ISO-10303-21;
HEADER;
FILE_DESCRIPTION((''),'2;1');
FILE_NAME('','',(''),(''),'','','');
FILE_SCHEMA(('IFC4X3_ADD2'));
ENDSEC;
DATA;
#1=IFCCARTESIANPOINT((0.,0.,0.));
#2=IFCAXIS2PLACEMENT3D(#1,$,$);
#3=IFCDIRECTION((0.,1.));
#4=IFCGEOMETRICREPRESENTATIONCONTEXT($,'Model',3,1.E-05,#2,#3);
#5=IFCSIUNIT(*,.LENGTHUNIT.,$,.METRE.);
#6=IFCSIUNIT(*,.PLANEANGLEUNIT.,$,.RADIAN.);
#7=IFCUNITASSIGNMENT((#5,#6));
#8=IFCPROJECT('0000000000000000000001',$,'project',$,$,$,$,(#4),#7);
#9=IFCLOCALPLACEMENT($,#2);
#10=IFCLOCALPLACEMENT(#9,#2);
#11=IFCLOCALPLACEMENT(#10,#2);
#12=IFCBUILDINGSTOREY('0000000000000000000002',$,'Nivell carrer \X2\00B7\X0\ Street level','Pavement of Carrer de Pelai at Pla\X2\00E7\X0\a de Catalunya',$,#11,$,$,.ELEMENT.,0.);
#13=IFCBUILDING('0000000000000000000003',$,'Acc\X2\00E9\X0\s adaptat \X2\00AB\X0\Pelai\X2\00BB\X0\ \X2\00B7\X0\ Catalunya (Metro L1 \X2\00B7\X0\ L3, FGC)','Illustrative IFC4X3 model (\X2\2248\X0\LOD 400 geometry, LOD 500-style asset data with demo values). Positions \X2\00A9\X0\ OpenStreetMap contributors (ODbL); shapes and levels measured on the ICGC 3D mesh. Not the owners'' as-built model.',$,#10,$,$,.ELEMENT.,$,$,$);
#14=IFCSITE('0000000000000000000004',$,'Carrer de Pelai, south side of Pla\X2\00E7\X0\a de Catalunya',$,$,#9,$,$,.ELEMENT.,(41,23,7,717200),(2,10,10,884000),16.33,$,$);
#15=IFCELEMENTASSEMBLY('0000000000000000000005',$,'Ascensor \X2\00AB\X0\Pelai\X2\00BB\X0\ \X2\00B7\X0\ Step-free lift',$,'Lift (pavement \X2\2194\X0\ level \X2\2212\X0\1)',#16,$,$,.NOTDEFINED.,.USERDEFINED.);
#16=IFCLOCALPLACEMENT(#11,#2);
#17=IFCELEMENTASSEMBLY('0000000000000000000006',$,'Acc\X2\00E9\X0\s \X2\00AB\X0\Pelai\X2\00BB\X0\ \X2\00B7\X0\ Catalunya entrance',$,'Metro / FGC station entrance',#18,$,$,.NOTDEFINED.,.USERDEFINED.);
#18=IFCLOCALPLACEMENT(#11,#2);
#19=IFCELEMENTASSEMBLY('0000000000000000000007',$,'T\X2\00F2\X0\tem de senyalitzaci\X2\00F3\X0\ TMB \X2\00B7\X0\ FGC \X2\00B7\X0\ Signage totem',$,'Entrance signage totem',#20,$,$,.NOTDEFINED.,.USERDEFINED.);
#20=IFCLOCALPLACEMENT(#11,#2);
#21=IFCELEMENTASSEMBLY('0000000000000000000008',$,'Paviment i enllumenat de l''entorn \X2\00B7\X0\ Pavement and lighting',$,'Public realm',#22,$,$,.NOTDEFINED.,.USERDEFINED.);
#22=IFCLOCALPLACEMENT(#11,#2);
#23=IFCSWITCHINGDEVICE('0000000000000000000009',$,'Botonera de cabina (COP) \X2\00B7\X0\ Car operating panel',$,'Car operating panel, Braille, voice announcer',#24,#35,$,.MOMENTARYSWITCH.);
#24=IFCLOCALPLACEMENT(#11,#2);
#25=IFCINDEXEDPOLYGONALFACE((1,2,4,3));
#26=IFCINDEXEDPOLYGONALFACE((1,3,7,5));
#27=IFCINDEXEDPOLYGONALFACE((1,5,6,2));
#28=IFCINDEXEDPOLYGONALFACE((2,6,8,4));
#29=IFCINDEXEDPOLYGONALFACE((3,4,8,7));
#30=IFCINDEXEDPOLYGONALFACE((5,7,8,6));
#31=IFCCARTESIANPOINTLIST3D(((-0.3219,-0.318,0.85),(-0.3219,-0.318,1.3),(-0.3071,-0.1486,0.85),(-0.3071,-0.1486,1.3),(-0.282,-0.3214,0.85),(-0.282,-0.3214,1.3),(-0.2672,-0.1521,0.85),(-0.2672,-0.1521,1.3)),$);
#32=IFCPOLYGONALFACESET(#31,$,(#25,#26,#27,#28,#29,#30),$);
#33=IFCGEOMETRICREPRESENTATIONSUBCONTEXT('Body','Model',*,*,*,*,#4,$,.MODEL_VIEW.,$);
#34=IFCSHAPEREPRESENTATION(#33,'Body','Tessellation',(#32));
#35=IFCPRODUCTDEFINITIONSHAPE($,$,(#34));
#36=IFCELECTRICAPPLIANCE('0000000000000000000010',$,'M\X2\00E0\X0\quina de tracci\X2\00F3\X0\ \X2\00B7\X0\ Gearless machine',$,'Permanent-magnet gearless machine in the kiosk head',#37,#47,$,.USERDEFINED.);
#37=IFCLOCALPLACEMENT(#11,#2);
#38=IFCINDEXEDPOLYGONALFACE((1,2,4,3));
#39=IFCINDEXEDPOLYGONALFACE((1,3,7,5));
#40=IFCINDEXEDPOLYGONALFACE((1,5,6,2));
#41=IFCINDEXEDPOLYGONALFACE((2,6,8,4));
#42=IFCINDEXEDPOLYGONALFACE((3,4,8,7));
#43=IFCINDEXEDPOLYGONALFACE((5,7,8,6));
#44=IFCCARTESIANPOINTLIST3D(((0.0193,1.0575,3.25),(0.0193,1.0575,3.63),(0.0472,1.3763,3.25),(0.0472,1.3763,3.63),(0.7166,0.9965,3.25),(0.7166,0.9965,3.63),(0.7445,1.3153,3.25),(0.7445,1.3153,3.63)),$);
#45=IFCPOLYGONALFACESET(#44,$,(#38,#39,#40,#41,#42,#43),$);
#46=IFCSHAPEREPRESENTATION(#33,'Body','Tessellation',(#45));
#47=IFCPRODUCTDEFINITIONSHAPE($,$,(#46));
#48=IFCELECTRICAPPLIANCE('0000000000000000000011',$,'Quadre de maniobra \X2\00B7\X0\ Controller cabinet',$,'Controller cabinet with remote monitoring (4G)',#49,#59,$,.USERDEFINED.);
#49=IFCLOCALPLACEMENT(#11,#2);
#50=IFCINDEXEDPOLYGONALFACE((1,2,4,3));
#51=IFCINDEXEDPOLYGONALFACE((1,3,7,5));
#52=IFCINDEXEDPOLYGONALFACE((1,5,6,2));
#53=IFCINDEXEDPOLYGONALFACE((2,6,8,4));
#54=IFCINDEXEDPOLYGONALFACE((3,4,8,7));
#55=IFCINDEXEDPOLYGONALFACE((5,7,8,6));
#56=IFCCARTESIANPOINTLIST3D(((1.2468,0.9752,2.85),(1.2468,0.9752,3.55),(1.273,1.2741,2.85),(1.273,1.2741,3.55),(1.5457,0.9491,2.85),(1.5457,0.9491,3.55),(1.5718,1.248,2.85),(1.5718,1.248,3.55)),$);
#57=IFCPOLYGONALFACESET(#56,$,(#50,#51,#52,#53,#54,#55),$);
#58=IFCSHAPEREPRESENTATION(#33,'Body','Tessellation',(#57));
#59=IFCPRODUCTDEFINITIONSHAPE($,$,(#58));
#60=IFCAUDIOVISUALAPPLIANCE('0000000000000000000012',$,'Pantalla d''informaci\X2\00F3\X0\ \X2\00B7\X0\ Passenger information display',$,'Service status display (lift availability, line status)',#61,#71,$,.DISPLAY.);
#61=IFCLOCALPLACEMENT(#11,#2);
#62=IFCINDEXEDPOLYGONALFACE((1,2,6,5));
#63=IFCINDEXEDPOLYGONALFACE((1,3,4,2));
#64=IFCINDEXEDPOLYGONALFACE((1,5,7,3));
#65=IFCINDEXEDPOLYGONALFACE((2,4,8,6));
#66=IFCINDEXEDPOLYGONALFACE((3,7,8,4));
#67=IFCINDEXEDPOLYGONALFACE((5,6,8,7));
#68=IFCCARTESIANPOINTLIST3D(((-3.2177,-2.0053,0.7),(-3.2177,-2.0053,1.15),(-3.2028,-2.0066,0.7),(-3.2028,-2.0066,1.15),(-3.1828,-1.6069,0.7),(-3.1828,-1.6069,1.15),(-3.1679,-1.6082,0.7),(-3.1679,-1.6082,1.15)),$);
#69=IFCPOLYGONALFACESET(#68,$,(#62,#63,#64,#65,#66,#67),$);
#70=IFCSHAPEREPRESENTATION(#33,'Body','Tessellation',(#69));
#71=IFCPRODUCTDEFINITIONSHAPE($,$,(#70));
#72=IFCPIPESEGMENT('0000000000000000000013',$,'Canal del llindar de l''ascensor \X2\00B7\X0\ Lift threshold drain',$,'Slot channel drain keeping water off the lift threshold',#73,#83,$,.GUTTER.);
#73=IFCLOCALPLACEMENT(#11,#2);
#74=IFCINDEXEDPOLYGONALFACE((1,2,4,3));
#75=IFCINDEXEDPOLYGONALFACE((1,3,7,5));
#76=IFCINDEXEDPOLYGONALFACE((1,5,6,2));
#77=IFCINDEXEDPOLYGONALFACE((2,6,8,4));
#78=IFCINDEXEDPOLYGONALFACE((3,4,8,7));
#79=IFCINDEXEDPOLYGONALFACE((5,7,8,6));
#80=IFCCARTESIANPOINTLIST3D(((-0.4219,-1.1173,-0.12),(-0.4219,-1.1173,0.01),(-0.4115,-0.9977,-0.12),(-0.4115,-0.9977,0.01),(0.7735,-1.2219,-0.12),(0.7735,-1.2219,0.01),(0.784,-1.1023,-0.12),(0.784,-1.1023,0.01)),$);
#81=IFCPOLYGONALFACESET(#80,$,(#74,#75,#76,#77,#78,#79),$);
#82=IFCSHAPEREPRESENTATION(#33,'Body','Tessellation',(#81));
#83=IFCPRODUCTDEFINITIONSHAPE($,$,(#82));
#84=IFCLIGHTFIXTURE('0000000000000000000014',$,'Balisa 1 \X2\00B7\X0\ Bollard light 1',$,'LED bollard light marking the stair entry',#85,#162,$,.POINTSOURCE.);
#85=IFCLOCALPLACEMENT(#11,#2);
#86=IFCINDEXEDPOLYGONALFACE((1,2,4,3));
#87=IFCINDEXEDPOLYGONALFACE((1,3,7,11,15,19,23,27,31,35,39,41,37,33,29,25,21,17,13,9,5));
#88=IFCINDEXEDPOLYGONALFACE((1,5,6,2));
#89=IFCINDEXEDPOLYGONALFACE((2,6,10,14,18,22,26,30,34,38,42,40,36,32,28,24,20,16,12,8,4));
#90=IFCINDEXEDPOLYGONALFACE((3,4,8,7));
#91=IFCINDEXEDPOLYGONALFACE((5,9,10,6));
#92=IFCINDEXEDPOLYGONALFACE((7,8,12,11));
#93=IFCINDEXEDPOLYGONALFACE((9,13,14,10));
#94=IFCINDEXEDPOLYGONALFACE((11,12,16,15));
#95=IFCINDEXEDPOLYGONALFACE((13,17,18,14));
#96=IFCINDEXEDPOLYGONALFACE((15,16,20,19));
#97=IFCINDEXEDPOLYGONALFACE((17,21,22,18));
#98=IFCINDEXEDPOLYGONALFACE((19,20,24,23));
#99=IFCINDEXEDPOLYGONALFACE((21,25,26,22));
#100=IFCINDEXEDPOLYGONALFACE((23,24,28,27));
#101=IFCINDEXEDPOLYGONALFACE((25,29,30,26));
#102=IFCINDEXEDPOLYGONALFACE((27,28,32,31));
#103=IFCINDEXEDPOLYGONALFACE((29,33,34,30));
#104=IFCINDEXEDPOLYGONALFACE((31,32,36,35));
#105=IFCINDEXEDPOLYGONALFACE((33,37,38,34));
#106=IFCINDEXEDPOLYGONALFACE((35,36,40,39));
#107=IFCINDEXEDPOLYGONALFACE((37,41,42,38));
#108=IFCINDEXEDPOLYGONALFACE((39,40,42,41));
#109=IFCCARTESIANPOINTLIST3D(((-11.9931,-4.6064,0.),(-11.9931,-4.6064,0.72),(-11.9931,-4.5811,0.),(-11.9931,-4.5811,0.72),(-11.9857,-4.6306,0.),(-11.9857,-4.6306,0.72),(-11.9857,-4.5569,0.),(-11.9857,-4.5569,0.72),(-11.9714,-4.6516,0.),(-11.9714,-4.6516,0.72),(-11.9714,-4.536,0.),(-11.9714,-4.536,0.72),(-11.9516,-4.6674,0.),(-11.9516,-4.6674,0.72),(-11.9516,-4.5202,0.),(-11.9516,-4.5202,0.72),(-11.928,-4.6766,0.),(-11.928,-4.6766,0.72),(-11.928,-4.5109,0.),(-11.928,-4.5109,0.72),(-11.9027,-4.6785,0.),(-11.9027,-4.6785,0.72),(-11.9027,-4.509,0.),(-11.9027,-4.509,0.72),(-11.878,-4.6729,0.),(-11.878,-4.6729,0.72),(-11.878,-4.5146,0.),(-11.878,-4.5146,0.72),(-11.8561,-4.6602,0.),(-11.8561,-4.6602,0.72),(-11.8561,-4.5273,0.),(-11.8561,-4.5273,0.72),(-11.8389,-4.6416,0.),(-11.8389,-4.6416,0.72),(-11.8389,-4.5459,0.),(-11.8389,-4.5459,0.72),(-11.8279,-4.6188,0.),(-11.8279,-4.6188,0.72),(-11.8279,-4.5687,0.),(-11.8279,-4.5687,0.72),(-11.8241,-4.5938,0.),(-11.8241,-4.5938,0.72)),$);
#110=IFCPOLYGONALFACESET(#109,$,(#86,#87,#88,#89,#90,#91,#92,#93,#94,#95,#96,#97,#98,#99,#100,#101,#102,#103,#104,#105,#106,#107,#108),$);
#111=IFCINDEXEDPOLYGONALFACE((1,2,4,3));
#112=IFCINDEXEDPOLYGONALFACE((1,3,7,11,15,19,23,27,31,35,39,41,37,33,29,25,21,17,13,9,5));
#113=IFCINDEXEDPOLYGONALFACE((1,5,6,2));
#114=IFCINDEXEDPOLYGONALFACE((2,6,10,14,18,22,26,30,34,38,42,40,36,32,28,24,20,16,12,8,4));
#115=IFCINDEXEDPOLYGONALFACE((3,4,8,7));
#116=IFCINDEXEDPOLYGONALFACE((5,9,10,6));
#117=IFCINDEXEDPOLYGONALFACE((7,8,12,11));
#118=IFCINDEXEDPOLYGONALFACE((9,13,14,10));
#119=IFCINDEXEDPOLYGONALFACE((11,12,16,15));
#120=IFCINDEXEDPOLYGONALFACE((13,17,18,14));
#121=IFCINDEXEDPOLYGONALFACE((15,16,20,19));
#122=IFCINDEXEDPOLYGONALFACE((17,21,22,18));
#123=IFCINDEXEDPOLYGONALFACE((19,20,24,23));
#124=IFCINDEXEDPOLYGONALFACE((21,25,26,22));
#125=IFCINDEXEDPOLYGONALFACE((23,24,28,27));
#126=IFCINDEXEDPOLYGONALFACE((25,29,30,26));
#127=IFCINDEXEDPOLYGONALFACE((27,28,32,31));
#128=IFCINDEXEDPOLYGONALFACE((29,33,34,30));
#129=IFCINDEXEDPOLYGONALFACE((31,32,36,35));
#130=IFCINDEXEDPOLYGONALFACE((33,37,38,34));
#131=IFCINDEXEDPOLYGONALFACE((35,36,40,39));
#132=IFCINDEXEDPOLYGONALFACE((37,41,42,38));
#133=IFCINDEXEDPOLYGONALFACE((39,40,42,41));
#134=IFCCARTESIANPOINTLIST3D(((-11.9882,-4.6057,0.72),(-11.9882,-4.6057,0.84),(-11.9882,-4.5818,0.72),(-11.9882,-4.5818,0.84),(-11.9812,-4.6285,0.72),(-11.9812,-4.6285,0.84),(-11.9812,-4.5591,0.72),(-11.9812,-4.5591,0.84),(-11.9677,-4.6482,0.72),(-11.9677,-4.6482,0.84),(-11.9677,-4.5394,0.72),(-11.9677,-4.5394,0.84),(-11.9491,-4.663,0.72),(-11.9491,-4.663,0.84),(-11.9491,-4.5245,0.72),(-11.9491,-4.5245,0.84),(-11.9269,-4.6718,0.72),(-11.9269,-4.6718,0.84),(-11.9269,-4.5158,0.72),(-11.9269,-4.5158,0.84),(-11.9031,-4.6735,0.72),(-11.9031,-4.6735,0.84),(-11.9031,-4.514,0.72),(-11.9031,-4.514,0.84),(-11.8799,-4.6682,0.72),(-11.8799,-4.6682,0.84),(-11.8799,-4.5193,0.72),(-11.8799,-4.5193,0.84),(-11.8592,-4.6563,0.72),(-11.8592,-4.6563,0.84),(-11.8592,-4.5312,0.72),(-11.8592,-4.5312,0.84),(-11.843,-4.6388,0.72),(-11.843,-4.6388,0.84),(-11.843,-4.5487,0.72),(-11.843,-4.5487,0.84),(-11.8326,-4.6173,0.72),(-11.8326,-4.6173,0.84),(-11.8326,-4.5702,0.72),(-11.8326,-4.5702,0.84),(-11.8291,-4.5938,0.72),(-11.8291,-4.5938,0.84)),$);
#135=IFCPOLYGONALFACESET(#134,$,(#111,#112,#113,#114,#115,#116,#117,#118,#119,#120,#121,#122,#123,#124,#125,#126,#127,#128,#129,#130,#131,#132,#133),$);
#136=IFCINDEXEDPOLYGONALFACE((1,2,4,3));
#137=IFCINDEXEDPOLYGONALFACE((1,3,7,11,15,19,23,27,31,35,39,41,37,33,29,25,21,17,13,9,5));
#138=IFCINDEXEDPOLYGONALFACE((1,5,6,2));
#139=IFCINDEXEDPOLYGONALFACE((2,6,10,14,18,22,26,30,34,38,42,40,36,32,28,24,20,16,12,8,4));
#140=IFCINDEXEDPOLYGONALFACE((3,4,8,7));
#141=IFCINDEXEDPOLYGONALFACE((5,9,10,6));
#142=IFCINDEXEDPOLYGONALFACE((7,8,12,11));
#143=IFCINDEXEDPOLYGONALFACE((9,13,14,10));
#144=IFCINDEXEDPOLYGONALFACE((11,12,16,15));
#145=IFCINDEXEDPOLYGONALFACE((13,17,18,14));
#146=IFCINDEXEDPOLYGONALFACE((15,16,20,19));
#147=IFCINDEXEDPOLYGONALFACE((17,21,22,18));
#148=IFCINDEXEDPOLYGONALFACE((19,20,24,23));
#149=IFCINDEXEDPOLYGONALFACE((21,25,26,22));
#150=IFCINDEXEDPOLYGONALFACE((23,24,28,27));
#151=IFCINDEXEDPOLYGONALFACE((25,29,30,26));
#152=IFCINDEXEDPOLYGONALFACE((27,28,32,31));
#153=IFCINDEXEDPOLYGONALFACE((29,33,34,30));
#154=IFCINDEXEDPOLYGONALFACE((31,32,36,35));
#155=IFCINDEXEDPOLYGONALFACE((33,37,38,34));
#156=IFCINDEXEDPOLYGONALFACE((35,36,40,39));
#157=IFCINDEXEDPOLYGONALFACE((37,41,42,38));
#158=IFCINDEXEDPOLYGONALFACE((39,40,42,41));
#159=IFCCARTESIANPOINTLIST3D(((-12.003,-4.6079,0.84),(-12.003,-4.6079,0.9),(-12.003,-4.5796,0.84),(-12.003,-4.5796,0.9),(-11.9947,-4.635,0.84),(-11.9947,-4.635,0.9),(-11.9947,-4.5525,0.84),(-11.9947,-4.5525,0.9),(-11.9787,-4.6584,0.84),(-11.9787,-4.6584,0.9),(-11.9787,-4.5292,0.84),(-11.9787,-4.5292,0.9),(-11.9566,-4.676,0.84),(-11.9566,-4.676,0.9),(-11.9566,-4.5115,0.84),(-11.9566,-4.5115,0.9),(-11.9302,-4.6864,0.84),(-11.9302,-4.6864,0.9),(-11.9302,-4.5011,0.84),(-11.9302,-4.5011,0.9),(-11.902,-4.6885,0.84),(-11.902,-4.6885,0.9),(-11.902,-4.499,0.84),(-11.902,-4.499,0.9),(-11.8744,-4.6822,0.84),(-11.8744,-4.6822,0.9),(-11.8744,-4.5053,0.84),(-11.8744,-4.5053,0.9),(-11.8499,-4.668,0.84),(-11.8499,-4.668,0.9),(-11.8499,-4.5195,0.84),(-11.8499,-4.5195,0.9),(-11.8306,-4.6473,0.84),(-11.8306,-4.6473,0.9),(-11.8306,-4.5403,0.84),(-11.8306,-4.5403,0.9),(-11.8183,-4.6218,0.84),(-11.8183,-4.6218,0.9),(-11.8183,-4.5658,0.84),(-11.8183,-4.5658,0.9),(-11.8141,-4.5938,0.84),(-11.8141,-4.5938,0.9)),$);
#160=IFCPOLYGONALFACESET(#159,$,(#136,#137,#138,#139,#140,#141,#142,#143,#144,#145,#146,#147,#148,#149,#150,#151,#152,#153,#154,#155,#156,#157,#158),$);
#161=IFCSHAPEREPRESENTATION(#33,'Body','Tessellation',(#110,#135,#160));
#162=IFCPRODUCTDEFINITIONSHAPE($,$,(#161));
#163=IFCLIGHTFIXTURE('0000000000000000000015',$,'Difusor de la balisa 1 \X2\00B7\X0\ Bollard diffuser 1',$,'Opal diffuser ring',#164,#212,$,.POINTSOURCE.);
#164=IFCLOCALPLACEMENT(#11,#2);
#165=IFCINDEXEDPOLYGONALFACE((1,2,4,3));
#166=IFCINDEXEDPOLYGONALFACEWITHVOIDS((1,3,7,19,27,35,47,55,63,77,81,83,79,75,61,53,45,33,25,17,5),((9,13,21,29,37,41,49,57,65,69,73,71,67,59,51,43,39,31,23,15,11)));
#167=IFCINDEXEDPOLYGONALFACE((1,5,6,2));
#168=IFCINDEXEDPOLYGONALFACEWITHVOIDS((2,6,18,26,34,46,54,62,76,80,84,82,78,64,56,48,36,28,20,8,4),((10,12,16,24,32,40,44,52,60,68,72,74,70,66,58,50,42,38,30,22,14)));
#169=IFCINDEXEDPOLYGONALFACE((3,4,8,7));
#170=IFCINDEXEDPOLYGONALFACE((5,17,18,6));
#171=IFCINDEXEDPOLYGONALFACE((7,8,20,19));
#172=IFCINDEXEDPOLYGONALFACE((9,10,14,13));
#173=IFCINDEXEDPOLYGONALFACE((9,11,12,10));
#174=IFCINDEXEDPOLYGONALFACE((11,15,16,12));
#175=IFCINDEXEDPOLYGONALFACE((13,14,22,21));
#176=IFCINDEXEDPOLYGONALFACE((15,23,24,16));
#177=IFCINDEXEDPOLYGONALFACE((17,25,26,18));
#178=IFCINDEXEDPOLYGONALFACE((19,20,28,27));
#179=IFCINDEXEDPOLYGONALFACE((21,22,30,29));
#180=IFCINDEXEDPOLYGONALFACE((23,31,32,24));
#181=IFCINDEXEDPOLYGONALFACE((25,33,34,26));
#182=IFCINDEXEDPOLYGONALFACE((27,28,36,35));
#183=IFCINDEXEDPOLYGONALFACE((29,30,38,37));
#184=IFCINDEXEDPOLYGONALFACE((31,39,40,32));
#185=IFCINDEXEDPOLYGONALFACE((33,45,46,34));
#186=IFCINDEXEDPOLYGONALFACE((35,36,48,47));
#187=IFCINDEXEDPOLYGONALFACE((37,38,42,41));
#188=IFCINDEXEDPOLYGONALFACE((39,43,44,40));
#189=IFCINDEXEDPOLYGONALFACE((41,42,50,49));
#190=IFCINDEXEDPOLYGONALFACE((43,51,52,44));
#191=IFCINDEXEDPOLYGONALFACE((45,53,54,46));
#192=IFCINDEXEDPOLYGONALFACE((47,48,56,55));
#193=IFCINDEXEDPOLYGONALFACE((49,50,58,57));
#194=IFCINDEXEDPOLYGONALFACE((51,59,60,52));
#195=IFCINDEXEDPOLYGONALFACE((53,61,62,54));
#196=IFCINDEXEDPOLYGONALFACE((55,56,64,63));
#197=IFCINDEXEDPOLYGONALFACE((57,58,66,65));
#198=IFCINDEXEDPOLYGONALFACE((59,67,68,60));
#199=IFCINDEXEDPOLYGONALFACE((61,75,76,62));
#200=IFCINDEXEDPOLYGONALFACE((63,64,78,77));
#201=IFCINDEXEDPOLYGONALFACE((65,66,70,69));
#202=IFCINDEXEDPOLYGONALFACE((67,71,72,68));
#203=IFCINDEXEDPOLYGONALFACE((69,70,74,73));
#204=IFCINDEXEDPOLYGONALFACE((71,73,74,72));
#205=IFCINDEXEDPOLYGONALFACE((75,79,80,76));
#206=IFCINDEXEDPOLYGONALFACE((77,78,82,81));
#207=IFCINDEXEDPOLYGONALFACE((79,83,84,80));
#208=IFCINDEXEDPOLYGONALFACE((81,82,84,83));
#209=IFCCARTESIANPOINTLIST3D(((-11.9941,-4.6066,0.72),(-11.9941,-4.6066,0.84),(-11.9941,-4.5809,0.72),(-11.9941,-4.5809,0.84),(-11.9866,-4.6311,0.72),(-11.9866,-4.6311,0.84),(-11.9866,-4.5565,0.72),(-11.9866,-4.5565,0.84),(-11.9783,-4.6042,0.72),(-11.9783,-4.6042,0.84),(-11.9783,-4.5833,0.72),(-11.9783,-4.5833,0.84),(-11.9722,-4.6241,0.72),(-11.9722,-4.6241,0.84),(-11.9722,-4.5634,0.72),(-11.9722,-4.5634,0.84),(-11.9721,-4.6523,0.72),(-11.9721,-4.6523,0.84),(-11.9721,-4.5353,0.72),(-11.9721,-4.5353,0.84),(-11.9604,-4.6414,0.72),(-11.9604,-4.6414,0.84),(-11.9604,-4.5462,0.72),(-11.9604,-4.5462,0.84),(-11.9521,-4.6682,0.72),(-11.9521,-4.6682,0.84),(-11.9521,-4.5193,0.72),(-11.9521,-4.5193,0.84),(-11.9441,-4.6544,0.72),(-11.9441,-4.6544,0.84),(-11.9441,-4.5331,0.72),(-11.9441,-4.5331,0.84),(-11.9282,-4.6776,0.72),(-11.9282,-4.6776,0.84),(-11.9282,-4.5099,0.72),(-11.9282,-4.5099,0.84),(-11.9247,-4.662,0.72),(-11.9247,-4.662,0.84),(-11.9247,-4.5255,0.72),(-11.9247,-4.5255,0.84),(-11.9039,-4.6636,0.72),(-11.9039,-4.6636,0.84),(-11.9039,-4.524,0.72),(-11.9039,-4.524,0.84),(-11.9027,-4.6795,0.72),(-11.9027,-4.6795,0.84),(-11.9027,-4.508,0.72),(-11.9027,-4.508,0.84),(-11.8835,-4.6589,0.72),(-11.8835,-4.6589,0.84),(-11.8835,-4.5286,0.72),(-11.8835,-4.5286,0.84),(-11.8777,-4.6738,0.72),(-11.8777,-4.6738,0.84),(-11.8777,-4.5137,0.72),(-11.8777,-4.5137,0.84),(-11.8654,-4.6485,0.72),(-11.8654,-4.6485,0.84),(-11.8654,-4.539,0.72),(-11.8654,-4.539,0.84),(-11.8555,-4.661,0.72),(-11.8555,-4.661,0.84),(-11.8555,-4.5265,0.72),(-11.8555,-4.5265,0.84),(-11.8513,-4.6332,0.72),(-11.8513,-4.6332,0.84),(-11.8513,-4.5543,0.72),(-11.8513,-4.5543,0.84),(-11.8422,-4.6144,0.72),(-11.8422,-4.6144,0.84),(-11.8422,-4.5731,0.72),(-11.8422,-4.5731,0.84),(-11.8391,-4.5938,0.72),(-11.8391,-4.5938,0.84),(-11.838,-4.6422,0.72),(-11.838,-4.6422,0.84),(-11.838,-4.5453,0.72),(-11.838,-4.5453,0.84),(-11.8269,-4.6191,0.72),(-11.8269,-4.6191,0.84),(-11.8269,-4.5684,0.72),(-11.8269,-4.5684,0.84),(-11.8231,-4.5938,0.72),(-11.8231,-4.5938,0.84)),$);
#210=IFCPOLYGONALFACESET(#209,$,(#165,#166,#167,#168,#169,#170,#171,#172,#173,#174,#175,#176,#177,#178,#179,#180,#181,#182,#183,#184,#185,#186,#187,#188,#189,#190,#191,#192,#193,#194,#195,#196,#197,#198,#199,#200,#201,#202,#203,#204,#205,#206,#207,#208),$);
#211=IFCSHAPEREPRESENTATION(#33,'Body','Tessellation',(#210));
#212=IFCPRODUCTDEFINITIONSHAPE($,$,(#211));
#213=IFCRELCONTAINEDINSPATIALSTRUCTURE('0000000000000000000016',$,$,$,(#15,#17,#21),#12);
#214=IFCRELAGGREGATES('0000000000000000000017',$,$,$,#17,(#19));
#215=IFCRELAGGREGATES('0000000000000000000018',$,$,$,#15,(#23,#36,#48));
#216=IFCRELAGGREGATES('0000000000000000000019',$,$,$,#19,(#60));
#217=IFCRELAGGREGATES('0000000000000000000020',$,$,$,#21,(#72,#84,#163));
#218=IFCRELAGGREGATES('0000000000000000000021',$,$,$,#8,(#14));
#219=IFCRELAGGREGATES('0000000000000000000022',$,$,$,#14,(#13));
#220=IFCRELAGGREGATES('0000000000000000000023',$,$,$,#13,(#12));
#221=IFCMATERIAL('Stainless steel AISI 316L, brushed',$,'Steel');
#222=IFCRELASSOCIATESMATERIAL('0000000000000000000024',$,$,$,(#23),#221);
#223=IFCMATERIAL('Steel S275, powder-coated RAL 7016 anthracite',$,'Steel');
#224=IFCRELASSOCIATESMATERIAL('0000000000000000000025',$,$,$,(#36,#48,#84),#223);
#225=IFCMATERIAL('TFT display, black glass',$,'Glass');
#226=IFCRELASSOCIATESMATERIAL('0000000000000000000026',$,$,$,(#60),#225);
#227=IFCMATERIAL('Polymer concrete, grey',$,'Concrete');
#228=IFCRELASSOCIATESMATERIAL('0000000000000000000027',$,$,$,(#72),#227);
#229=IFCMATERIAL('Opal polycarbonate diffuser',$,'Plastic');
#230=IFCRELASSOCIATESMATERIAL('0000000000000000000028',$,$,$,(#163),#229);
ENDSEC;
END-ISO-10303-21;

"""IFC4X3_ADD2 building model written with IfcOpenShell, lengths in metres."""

from ifc_helpers import new_model, si_unit, direction, frame, frame_2d, origin, origin_2d_with_axis, place, context, subcontext, project, spatial, rectangle, circle, hollow_circle, extrude, material, element, aggregate, save


model = new_model("IFC4X3_ADD2")

# Units and contexts
model_context = context("Model", 3, precision=1e-05, world=origin(), true_north=direction((0.0, 1.0)))
body_context = subcontext(model_context, "Body", "Model", "MODEL_VIEW")
ifc_project = project(units=[si_unit("LENGTHUNIT", "METRE"), si_unit("PLANEANGLEUNIT", "RADIAN")], contexts=[model_context])

# Site, building, storey
site_placement = place(None, origin())
site = spatial("IfcSite", under=ifc_project, at=site_placement, Name="Carrer de Pelai, south side of Plaça de Catalunya", CompositionType="ELEMENT", RefLatitude=(41, 23, 7, 717200), RefLongitude=(2, 10, 10, 884000), RefElevation=16.33)
building_placement = place(site_placement, origin())
building = spatial("IfcBuilding", under=site, at=building_placement, Name="Accés adaptat «Pelai» · Catalunya (Metro L1 · L3, FGC)", Description="Illustrative IFC4X3 model (≈LOD 400 geometry, LOD 500-style asset data with demo values). Positions © OpenStreetMap contributors (ODbL); shapes and levels measured on the ICGC 3D mesh. Not the owners' as-built model.", CompositionType="ELEMENT")
storey_placement = place(building_placement, origin())
storey = spatial("IfcBuildingStorey", under=building, at=storey_placement, Name="Nivell carrer · Street level", Description="Pavement of Carrer de Pelai at Plaça de Catalunya", CompositionType="ELEMENT", Elevation=0.0)

# Element assembly
assembly_1_placement = place(building_placement, origin())
assembly_1 = element("IfcElementAssembly", 1, at=assembly_1_placement, inside=storey, Name="Ascensor «Pelai» · Step-free lift", ObjectType="Lift (pavement ↔ level −1)", AssemblyPlace="NOTDEFINED", PredefinedType="USERDEFINED")
ifc_material_1 = material(Name="Stainless steel AISI 316L, brushed", Category="Steel")
ifc_material_2 = material(Name="Steel S275, powder-coated RAL 7016 anthracite", Category="Steel")

# Element assemblies
assembly_2_placement = place(building_placement, origin())
assembly_2 = element("IfcElementAssembly", 2, at=assembly_2_placement, inside=storey, Name="Accés «Pelai» · Catalunya entrance", ObjectType="Metro / FGC station entrance", AssemblyPlace="NOTDEFINED", PredefinedType="USERDEFINED")
assembly_3_placement = place(building_placement, origin())
assembly_3 = element("IfcElementAssembly", 3, at=assembly_3_placement, Name="Tòtem de senyalització TMB · FGC · Signage totem", ObjectType="Entrance signage totem", AssemblyPlace="NOTDEFINED", PredefinedType="USERDEFINED")
aggregate(assembly_2, [assembly_3])

# Element assembly
assembly_4_placement = place(building_placement, origin())
assembly_4 = element("IfcElementAssembly", 4, at=assembly_4_placement, inside=storey, Name="Paviment i enllumenat de l'entorn · Pavement and lighting", ObjectType="Public realm", AssemblyPlace="NOTDEFINED", PredefinedType="USERDEFINED")

# Shared definitions
ifc_material_3 = material(Name="Opal polycarbonate diffuser", Category="Plastic")

# Switching device
switching_device_1_placement = place(building_placement, origin())
switching_device_1 = element("IfcSwitchingDevice", 5, at=switching_device_1_placement, material=ifc_material_1, Name="Botonera de cabina (COP) · Car operating panel", ObjectType="Car operating panel, Braille, voice announcer", PredefinedType="MOMENTARYSWITCH", context=body_context, shape_type="SweptSolid", body=[
    extrude(rectangle(XDim=0.04, YDim=0.17, at=frame_2d((0.0, 0.0), x_axis=(0.996195, -0.087156))), frame((-0.2945, -0.235, 0.85)), (0.0, 0.0, 1.0), 0.45),
])

# Electric appliances
electric_appliance_1_placement = place(building_placement, origin())
electric_appliance_1 = element("IfcElectricAppliance", 6, at=electric_appliance_1_placement, material=ifc_material_2, Name="Màquina de tracció · Gearless machine", ObjectType="Permanent-magnet gearless machine in the kiosk head", PredefinedType="USERDEFINED", context=body_context, shape_type="SweptSolid", body=[
    extrude(rectangle(XDim=0.7, YDim=0.32, at=frame_2d((0.0, 0.0), x_axis=(0.996195, -0.087156))), frame((0.3819, 1.1864, 3.25)), (0.0, 0.0, 1.0), 0.38),
])
electric_appliance_2_placement = place(building_placement, origin())
electric_appliance_2 = element("IfcElectricAppliance", 7, at=electric_appliance_2_placement, material=ifc_material_2, Name="Quadre de maniobra · Controller cabinet", ObjectType="Controller cabinet with remote monitoring (4G)", PredefinedType="USERDEFINED", context=body_context, shape_type="SweptSolid", body=[
    extrude(rectangle(XDim=0.3, YDim=0.3, at=frame_2d((0.0, 0.0), x_axis=(0.996195, -0.087156))), frame((1.4093, 1.1116, 2.85)), (0.0, 0.0, 1.0), 0.7),
])

# Audio visual appliance
ifc_material_4 = material(Name="TFT display, black glass", Category="Glass")
audio_visual_appliance_placement = place(building_placement, origin())
audio_visual_appliance = element("IfcAudioVisualAppliance", 8, at=audio_visual_appliance_placement, material=ifc_material_4, Name="Pantalla d'informació · Passenger information display", ObjectType="Service status display (lift availability, line status)", PredefinedType="DISPLAY", context=body_context, shape_type="SweptSolid", body=[
    extrude(rectangle(XDim=0.015, YDim=0.4, at=frame_2d((0.0, 0.0), x_axis=(0.996195, -0.087156))), frame((-3.1928, -1.8068, 0.7)), (0.0, 0.0, 1.0), 0.45),
])

# Pipe segment
ifc_material_5 = material(Name="Polymer concrete, grey", Category="Concrete")
pipe_segment_placement = place(building_placement, origin())
pipe_segment = element("IfcPipeSegment", 9, at=pipe_segment_placement, material=ifc_material_5, Name="Canal del llindar de l'ascensor · Lift threshold drain", ObjectType="Slot channel drain keeping water off the lift threshold", PredefinedType="GUTTER", context=body_context, shape_type="SweptSolid", body=[
    extrude(rectangle(XDim=1.2, YDim=0.12, at=frame_2d((0.0, 0.0), x_axis=(0.996195, -0.087156))), frame((0.181, -1.1098, -0.12)), (0.0, 0.0, 1.0), 0.13),
])

# Light fixtures
light_fixture_1_placement = place(building_placement, origin())
light_fixture_1 = element("IfcLightFixture", 10, at=light_fixture_1_placement, material=ifc_material_2, Name="Balisa 1 · Bollard light 1", ObjectType="LED bollard light marking the stair entry", PredefinedType="POINTSOURCE", context=body_context, shape_type="SweptSolid", body=[
    extrude(circle(Radius=0.085, at=origin_2d_with_axis()), frame((-11.9091, -4.5938, 0.0)), (0.0, 0.0, 1.0), 0.72),
    extrude(circle(Radius=0.08, at=origin_2d_with_axis()), frame((-11.9091, -4.5938, 0.72)), (0.0, 0.0, 1.0), 0.12),
    extrude(circle(Radius=0.095, at=origin_2d_with_axis()), frame((-11.9091, -4.5938, 0.84)), (0.0, 0.0, 1.0), 0.06),
])
light_fixture_2_placement = place(building_placement, origin())
light_fixture_2 = element("IfcLightFixture", 11, at=light_fixture_2_placement, material=ifc_material_3, Name="Difusor de la balisa 1 · Bollard diffuser 1", ObjectType="Opal diffuser ring", PredefinedType="POINTSOURCE", context=body_context, shape_type="SweptSolid", body=[
    extrude(hollow_circle(Radius=0.086, WallThickness=0.016, at=origin_2d_with_axis()), frame((-11.9091, -4.5938, 0.72)), (0.0, 0.0, 1.0), 0.12),
])

aggregate(assembly_1, [switching_device_1, electric_appliance_1, electric_appliance_2])

aggregate(assembly_3, [audio_visual_appliance])

aggregate(assembly_4, [pipe_segment, light_fixture_1, light_fixture_2])

save(model, "model.ifc")
